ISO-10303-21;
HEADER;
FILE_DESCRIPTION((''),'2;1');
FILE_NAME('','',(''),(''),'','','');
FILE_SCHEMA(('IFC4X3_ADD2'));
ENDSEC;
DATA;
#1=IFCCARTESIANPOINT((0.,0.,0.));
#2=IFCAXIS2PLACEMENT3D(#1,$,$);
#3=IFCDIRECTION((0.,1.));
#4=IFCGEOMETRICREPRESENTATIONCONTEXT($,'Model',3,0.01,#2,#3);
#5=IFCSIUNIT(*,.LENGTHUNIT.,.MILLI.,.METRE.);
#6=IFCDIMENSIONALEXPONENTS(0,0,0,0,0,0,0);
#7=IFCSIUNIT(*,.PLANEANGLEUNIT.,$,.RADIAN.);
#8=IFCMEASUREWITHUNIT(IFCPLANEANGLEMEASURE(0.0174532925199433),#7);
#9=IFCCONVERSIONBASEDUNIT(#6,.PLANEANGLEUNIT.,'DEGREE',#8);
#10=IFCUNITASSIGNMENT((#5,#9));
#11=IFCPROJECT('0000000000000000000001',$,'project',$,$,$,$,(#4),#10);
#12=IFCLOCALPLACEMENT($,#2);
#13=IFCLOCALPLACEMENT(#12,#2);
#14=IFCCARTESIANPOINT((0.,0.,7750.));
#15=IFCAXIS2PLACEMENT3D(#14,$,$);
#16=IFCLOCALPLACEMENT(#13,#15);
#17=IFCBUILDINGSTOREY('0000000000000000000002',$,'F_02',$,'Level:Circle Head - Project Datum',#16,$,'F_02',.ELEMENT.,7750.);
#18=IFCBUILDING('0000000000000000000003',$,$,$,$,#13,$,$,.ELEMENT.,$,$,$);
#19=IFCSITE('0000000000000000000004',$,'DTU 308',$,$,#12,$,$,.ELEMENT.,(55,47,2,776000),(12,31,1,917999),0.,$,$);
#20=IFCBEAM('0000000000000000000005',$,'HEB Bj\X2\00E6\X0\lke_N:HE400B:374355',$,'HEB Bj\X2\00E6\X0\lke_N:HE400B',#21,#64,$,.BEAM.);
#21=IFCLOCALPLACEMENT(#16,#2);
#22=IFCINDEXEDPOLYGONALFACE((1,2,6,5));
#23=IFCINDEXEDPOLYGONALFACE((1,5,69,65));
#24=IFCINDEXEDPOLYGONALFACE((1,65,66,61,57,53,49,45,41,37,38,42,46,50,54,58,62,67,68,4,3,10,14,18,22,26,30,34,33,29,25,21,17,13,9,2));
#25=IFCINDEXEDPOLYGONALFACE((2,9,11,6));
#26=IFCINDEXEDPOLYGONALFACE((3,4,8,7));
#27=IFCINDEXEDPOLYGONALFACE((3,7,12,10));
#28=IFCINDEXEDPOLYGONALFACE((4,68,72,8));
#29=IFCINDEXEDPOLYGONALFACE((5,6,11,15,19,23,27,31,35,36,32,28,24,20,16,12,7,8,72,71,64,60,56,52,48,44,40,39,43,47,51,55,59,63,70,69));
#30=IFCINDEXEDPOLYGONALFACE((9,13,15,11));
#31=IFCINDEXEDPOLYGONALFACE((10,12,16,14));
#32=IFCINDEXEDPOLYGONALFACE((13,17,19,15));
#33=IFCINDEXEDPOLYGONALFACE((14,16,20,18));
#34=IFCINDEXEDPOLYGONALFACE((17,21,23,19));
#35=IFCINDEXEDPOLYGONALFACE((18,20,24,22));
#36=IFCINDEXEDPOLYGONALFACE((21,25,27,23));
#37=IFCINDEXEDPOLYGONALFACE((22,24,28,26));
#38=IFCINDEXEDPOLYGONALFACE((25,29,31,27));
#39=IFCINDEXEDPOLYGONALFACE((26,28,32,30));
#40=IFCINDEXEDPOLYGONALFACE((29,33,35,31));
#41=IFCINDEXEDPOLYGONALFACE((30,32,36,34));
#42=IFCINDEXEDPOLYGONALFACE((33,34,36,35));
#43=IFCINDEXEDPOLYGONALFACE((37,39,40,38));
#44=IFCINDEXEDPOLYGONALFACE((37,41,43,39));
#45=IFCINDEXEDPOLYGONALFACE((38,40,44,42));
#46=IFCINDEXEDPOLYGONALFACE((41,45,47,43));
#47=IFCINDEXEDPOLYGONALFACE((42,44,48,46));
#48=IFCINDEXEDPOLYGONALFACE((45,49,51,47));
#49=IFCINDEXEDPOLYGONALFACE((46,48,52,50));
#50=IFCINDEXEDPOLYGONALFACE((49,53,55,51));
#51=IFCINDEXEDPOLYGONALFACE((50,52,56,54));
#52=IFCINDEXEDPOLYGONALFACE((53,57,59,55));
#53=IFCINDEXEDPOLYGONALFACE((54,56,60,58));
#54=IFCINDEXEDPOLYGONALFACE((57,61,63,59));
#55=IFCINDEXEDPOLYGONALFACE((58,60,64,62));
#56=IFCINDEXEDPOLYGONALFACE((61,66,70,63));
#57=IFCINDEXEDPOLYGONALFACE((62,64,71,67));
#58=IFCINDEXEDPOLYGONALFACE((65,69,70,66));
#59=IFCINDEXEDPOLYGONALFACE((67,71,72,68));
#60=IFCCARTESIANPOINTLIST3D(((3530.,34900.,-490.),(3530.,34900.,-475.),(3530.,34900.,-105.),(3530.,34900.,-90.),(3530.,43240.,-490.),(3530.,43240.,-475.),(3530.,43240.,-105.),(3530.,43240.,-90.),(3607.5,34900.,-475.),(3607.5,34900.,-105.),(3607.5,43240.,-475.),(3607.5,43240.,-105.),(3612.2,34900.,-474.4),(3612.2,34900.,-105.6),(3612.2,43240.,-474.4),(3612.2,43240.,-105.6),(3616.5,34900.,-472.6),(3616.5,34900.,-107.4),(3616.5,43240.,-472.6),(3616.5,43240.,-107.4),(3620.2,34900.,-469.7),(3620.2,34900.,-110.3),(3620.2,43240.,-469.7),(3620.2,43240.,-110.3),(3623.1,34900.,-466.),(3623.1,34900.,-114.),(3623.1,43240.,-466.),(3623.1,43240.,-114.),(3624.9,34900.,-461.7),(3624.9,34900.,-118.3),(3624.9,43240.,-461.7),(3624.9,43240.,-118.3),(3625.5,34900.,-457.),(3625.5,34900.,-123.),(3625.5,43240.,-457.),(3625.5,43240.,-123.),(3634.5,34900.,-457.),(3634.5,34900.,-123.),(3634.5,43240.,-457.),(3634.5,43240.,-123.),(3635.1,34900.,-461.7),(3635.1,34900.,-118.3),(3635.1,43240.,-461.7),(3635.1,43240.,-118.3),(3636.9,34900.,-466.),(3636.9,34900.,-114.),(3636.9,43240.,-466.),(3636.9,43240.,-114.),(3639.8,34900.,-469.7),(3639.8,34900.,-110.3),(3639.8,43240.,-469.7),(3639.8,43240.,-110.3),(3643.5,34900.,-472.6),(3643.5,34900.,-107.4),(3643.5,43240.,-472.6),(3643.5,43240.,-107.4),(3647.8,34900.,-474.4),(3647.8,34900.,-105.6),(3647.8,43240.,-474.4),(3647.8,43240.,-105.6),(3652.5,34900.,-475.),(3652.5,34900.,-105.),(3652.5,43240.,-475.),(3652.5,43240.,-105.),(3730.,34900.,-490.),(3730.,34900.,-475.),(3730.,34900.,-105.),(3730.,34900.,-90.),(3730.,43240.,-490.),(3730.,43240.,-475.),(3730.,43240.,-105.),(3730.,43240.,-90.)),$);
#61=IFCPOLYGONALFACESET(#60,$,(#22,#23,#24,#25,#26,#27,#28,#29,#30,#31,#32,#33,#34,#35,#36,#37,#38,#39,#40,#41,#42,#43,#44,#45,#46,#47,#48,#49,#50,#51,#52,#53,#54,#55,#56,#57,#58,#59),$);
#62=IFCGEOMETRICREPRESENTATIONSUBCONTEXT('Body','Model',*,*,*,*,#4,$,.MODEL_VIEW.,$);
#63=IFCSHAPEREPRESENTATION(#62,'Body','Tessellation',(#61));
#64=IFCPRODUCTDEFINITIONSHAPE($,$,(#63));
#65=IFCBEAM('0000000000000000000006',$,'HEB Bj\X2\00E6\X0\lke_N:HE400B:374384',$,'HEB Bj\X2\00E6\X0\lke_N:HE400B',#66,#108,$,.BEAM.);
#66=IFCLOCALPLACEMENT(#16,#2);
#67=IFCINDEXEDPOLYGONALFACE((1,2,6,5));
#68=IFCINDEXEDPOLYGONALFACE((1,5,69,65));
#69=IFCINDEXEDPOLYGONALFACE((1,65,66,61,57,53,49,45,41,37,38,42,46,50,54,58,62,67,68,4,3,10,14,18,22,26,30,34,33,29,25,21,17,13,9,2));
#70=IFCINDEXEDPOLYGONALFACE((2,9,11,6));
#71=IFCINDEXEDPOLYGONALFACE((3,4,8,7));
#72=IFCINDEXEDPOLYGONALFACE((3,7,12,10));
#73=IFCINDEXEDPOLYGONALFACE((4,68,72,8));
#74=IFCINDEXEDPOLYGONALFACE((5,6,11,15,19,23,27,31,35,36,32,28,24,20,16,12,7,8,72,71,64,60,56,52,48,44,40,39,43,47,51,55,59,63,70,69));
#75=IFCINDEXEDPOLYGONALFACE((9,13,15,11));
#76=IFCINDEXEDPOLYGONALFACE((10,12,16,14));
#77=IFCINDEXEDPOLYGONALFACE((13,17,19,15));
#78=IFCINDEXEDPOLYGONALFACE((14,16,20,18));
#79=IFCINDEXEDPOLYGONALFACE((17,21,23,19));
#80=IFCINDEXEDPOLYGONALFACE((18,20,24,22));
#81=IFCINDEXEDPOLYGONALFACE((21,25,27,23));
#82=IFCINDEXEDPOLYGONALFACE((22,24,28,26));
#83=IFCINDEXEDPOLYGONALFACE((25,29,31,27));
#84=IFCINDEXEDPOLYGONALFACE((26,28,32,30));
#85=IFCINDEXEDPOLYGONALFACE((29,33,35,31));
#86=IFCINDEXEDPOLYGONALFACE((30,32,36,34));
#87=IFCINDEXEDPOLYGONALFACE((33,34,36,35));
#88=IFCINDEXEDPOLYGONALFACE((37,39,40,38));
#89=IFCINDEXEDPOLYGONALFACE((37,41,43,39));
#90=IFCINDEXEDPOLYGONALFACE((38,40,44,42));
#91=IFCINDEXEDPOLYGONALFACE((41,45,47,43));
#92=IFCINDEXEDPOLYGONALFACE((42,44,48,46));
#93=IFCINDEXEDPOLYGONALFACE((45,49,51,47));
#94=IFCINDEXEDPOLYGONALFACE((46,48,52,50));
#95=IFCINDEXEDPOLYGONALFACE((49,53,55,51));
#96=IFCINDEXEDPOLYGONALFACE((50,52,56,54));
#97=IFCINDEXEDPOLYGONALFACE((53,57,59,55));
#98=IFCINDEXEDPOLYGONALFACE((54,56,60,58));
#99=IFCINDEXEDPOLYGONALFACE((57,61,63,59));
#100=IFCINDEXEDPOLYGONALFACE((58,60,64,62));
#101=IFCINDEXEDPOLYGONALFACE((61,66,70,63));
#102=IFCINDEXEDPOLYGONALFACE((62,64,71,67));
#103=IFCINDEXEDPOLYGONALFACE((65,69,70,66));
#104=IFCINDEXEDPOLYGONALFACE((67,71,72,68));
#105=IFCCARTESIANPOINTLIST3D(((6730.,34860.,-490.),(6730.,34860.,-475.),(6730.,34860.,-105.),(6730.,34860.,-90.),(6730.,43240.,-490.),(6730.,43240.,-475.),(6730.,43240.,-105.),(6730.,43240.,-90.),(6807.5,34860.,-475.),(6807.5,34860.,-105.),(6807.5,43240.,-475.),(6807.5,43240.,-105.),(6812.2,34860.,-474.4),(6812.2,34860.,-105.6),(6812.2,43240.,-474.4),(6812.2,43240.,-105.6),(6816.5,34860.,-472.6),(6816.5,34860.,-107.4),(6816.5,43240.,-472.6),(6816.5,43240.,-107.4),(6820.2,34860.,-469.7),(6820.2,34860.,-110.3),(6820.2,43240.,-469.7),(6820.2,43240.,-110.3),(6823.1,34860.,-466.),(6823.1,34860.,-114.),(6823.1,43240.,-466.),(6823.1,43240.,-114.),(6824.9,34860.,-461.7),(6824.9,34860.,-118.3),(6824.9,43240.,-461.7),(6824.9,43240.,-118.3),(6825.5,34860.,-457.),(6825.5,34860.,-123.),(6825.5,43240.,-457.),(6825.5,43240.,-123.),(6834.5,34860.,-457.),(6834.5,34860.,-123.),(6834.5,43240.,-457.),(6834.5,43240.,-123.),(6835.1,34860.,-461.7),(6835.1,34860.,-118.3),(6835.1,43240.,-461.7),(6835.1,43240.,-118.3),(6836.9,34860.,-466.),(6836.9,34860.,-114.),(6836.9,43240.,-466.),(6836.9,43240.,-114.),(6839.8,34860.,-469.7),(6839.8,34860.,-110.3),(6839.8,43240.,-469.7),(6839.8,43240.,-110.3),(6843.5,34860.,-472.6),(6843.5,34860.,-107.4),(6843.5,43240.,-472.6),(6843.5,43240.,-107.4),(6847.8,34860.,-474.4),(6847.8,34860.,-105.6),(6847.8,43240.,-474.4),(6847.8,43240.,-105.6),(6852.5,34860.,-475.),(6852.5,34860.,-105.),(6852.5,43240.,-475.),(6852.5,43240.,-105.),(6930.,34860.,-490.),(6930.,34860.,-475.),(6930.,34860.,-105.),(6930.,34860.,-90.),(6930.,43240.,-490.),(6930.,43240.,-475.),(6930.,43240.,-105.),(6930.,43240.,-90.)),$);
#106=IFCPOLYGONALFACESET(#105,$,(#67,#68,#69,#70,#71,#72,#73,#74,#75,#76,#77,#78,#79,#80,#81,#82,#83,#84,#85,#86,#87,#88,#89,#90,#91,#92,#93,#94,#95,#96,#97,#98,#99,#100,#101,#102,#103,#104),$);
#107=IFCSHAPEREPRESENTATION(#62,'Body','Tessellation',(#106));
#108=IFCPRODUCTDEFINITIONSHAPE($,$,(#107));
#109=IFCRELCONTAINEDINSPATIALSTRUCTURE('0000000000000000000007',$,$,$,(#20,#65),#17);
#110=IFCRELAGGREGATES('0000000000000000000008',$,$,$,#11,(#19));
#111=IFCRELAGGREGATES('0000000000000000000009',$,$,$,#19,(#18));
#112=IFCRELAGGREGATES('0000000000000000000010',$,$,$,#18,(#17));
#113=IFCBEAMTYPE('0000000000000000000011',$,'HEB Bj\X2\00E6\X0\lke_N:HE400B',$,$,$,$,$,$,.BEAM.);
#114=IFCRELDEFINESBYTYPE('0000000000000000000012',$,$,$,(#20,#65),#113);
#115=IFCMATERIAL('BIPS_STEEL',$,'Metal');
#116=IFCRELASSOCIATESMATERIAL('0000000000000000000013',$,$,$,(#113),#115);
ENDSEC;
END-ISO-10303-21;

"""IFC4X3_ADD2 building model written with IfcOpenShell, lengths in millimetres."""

from ifc_helpers import new_model, entity, si_unit, converted_unit, direction, frame, frame_2d, origin, place, context, subcontext, project, spatial, polyline, circle_curve, parameter, trimmed, segment, composite_curve, outline, extrude, source, transform, mapped, material, material_profile, profile_set, type_object, element, save


model = new_model("IFC4X3_ADD2")

# Units and contexts
model_context = context("Model", 3, precision=0.01, world=origin(), true_north=direction((0.0, 1.0)))
body_context = subcontext(model_context, "Body", "Model", "MODEL_VIEW")
ifc_project = project(units=[si_unit("LENGTHUNIT", "METRE", prefix="MILLI"), converted_unit("PLANEANGLEUNIT", "DEGREE", entity("IfcPlaneAngleMeasure", 0.0174532925199433), si_unit("PLANEANGLEUNIT", "RADIAN"), dimensions=[0, 0, 0, 0, 0, 0, 0])], contexts=[model_context])

# Site, building, storey
site_placement = place(None, origin())
site = spatial("IfcSite", under=ifc_project, at=site_placement, Name="DTU 308", CompositionType="ELEMENT", RefLatitude=(55, 47, 2, 776000), RefLongitude=(12, 31, 1, 917999), RefElevation=0.0)
building_placement = place(site_placement, origin())
building = spatial("IfcBuilding", under=site, at=building_placement, CompositionType="ELEMENT")
storey_placement = place(building_placement, frame((0.0, 0.0, 7750.0)))
storey = spatial("IfcBuildingStorey", under=building, at=storey_placement, Name="F_02", ObjectType="Level:Circle Head - Project Datum", LongName="F_02", CompositionType="ELEMENT", Elevation=7750.0)

# Shared definitions
ifc_material = material(Name="BIPS_STEEL", Category="Metal")

# Beams
ifc_material_profile_1 = material_profile(ifc_material, outline(composite_curve([segment(polyline([(-100.0, -185.0), (-100.0, -200.0)]), True, "CONTINUOUS"), segment(polyline([(-100.0, -200.0), (100.0, -200.0)]), True, "CONTINUOUS"), segment(polyline([(100.0, -200.0), (100.0, -185.0)]), True, "CONTINUOUS"), segment(polyline([(100.0, -185.0), (22.5, -185.0)]), True, "CONTINUOUS"), segment(trimmed(circle_curve(frame_2d((22.5, -167.0), x_axis=(1.0, 0.0)), 18.0), [parameter(180.0)], [parameter(270.0)], True, "PARAMETER"), False, "CONTINUOUS"), segment(polyline([(4.5, -167.0), (4.5, 167.0)]), True, "CONTINUOUS"), segment(trimmed(circle_curve(frame_2d((22.5, 167.0), x_axis=(1.0, 0.0)), 18.0), [parameter(90.0)], [parameter(180.0)], True, "PARAMETER"), False, "CONTINUOUS"), segment(polyline([(22.5, 185.0), (100.0, 185.0)]), True, "CONTINUOUS"), segment(polyline([(100.0, 185.0), (100.0, 200.0)]), True, "CONTINUOUS"), segment(polyline([(100.0, 200.0), (-100.0, 200.0)]), True, "CONTINUOUS"), segment(polyline([(-100.0, 200.0), (-100.0, 185.0)]), True, "CONTINUOUS"), segment(polyline([(-100.0, 185.0), (-22.5, 185.0)]), True, "CONTINUOUS"), segment(trimmed(circle_curve(frame_2d((-22.5, 167.0), x_axis=(1.0, 0.0)), 18.0), [parameter(360.0)], [parameter(90.0)], True, "PARAMETER"), False, "CONTINUOUS"), segment(polyline([(-4.5, 167.0), (-4.5, -167.0)]), True, "CONTINUOUS"), segment(trimmed(circle_curve(frame_2d((-22.5, -167.0), x_axis=(1.0, 0.0)), 18.0), [parameter(270.0)], [parameter(360.0)], True, "PARAMETER"), False, "CONTINUOUS"), segment(polyline([(-22.5, -185.0), (-100.0, -185.0)]), True, "CONTINUOUS")], self_intersect=False)), Name="HE400B")
ifc_profile_set_1 = profile_set([ifc_material_profile_1], Name="HE400B")
beam_type_1 = type_object("IfcBeamType", Name="HEB Bjælke_N:HE400B", PredefinedType="BEAM", material=ifc_profile_set_1)
shared_shape_1 = source(origin(), body_context, "Body", "SweptSolid", [
    extrude(outline(composite_curve([segment(polyline([(-100.0, -185.0), (-100.0, -200.0)]), True, "CONTINUOUS"), segment(polyline([(-100.0, -200.0), (100.0, -200.0)]), True, "CONTINUOUS"), segment(polyline([(100.0, -200.0), (100.0, -185.0)]), True, "CONTINUOUS"), segment(polyline([(100.0, -185.0), (22.5, -185.0)]), True, "CONTINUOUS"), segment(trimmed(circle_curve(frame_2d((22.5, -167.0), x_axis=(1.0, 0.0)), 18.0), [parameter(180.0)], [parameter(270.0)], True, "PARAMETER"), False, "CONTINUOUS"), segment(polyline([(4.5, -167.0), (4.5, 167.0)]), True, "CONTINUOUS"), segment(trimmed(circle_curve(frame_2d((22.5, 167.0), x_axis=(1.0, 0.0)), 18.0), [parameter(90.0)], [parameter(180.0)], True, "PARAMETER"), False, "CONTINUOUS"), segment(polyline([(22.5, 185.0), (100.0, 185.0)]), True, "CONTINUOUS"), segment(polyline([(100.0, 185.0), (100.0, 200.0)]), True, "CONTINUOUS"), segment(polyline([(100.0, 200.0), (-100.0, 200.0)]), True, "CONTINUOUS"), segment(polyline([(-100.0, 200.0), (-100.0, 185.0)]), True, "CONTINUOUS"), segment(polyline([(-100.0, 185.0), (-22.5, 185.0)]), True, "CONTINUOUS"), segment(trimmed(circle_curve(frame_2d((-22.5, 167.0), x_axis=(1.0, 0.0)), 18.0), [parameter(360.0)], [parameter(90.0)], True, "PARAMETER"), False, "CONTINUOUS"), segment(polyline([(-4.5, 167.0), (-4.5, -167.0)]), True, "CONTINUOUS"), segment(trimmed(circle_curve(frame_2d((-22.5, -167.0), x_axis=(1.0, 0.0)), 18.0), [parameter(270.0)], [parameter(360.0)], True, "PARAMETER"), False, "CONTINUOUS"), segment(polyline([(-22.5, -185.0), (-100.0, -185.0)]), True, "CONTINUOUS")], self_intersect=False)), frame((-4280.0, 0.0, 0.0), z_axis=(-1.0, 0.0, 0.0), x_axis=(0.0, -1.0, 0.0)), (0.0, 0.0, -1.0), 8340.0),
])
beam_1_placement = place(storey_placement, frame((3630.0, 38960.0, -290.0), z_axis=(0.0, 0.0, 1.0), x_axis=(0.0, -1.0, 0.0)))
element("IfcBeam", 1, at=beam_1_placement, inside=storey, type_object=beam_type_1, Name="HEB Bjælke_N:HE400B:374355", ObjectType="HEB Bjælke_N:HE400B", PredefinedType="BEAM", context=body_context, shape_type="MappedRepresentation", body=[
    mapped(shared_shape_1, transform((0.0, 0.0, 0.0), scale=1.0)),
])
shared_shape_2 = source(origin(), body_context, "Body", "SweptSolid", [
    extrude(outline(composite_curve([segment(polyline([(-100.0, -185.0), (-100.0, -200.0)]), True, "CONTINUOUS"), segment(polyline([(-100.0, -200.0), (100.0, -200.0)]), True, "CONTINUOUS"), segment(polyline([(100.0, -200.0), (100.0, -185.0)]), True, "CONTINUOUS"), segment(polyline([(100.0, -185.0), (22.5, -185.0)]), True, "CONTINUOUS"), segment(trimmed(circle_curve(frame_2d((22.5, -167.0), x_axis=(1.0, 0.0)), 18.0), [parameter(180.0)], [parameter(270.0)], True, "PARAMETER"), False, "CONTINUOUS"), segment(polyline([(4.5, -167.0), (4.5, 167.0)]), True, "CONTINUOUS"), segment(trimmed(circle_curve(frame_2d((22.5, 167.0), x_axis=(1.0, 0.0)), 18.0), [parameter(90.0)], [parameter(180.0)], True, "PARAMETER"), False, "CONTINUOUS"), segment(polyline([(22.5, 185.0), (100.0, 185.0)]), True, "CONTINUOUS"), segment(polyline([(100.0, 185.0), (100.0, 200.0)]), True, "CONTINUOUS"), segment(polyline([(100.0, 200.0), (-100.0, 200.0)]), True, "CONTINUOUS"), segment(polyline([(-100.0, 200.0), (-100.0, 185.0)]), True, "CONTINUOUS"), segment(polyline([(-100.0, 185.0), (-22.5, 185.0)]), True, "CONTINUOUS"), segment(trimmed(circle_curve(frame_2d((-22.5, 167.0), x_axis=(1.0, 0.0)), 18.0), [parameter(360.0)], [parameter(90.0)], True, "PARAMETER"), False, "CONTINUOUS"), segment(polyline([(-4.5, 167.0), (-4.5, -167.0)]), True, "CONTINUOUS"), segment(trimmed(circle_curve(frame_2d((-22.5, -167.0), x_axis=(1.0, 0.0)), 18.0), [parameter(270.0)], [parameter(360.0)], True, "PARAMETER"), False, "CONTINUOUS"), segment(polyline([(-22.5, -185.0), (-100.0, -185.0)]), True, "CONTINUOUS")], self_intersect=False)), frame((-5920.0, 0.0, 0.0), z_axis=(-1.0, 0.0, 0.0), x_axis=(0.0, -1.0, 0.0)), (0.0, 0.0, -1.0), 8380.0),
])
beam_2_placement = place(storey_placement, frame((6830.0, 37320.0, -290.0), z_axis=(0.0, 0.0, 1.0), x_axis=(0.0, -1.0, 0.0)))
element("IfcBeam", 2, at=beam_2_placement, inside=storey, type_object=beam_type_1, Name="HEB Bjælke_N:HE400B:374384", ObjectType="HEB Bjælke_N:HE400B", PredefinedType="BEAM", context=body_context, shape_type="MappedRepresentation", body=[
    mapped(shared_shape_2, transform((0.0, 0.0, 0.0), scale=1.0)),
])

save(model, "model.ifc")
